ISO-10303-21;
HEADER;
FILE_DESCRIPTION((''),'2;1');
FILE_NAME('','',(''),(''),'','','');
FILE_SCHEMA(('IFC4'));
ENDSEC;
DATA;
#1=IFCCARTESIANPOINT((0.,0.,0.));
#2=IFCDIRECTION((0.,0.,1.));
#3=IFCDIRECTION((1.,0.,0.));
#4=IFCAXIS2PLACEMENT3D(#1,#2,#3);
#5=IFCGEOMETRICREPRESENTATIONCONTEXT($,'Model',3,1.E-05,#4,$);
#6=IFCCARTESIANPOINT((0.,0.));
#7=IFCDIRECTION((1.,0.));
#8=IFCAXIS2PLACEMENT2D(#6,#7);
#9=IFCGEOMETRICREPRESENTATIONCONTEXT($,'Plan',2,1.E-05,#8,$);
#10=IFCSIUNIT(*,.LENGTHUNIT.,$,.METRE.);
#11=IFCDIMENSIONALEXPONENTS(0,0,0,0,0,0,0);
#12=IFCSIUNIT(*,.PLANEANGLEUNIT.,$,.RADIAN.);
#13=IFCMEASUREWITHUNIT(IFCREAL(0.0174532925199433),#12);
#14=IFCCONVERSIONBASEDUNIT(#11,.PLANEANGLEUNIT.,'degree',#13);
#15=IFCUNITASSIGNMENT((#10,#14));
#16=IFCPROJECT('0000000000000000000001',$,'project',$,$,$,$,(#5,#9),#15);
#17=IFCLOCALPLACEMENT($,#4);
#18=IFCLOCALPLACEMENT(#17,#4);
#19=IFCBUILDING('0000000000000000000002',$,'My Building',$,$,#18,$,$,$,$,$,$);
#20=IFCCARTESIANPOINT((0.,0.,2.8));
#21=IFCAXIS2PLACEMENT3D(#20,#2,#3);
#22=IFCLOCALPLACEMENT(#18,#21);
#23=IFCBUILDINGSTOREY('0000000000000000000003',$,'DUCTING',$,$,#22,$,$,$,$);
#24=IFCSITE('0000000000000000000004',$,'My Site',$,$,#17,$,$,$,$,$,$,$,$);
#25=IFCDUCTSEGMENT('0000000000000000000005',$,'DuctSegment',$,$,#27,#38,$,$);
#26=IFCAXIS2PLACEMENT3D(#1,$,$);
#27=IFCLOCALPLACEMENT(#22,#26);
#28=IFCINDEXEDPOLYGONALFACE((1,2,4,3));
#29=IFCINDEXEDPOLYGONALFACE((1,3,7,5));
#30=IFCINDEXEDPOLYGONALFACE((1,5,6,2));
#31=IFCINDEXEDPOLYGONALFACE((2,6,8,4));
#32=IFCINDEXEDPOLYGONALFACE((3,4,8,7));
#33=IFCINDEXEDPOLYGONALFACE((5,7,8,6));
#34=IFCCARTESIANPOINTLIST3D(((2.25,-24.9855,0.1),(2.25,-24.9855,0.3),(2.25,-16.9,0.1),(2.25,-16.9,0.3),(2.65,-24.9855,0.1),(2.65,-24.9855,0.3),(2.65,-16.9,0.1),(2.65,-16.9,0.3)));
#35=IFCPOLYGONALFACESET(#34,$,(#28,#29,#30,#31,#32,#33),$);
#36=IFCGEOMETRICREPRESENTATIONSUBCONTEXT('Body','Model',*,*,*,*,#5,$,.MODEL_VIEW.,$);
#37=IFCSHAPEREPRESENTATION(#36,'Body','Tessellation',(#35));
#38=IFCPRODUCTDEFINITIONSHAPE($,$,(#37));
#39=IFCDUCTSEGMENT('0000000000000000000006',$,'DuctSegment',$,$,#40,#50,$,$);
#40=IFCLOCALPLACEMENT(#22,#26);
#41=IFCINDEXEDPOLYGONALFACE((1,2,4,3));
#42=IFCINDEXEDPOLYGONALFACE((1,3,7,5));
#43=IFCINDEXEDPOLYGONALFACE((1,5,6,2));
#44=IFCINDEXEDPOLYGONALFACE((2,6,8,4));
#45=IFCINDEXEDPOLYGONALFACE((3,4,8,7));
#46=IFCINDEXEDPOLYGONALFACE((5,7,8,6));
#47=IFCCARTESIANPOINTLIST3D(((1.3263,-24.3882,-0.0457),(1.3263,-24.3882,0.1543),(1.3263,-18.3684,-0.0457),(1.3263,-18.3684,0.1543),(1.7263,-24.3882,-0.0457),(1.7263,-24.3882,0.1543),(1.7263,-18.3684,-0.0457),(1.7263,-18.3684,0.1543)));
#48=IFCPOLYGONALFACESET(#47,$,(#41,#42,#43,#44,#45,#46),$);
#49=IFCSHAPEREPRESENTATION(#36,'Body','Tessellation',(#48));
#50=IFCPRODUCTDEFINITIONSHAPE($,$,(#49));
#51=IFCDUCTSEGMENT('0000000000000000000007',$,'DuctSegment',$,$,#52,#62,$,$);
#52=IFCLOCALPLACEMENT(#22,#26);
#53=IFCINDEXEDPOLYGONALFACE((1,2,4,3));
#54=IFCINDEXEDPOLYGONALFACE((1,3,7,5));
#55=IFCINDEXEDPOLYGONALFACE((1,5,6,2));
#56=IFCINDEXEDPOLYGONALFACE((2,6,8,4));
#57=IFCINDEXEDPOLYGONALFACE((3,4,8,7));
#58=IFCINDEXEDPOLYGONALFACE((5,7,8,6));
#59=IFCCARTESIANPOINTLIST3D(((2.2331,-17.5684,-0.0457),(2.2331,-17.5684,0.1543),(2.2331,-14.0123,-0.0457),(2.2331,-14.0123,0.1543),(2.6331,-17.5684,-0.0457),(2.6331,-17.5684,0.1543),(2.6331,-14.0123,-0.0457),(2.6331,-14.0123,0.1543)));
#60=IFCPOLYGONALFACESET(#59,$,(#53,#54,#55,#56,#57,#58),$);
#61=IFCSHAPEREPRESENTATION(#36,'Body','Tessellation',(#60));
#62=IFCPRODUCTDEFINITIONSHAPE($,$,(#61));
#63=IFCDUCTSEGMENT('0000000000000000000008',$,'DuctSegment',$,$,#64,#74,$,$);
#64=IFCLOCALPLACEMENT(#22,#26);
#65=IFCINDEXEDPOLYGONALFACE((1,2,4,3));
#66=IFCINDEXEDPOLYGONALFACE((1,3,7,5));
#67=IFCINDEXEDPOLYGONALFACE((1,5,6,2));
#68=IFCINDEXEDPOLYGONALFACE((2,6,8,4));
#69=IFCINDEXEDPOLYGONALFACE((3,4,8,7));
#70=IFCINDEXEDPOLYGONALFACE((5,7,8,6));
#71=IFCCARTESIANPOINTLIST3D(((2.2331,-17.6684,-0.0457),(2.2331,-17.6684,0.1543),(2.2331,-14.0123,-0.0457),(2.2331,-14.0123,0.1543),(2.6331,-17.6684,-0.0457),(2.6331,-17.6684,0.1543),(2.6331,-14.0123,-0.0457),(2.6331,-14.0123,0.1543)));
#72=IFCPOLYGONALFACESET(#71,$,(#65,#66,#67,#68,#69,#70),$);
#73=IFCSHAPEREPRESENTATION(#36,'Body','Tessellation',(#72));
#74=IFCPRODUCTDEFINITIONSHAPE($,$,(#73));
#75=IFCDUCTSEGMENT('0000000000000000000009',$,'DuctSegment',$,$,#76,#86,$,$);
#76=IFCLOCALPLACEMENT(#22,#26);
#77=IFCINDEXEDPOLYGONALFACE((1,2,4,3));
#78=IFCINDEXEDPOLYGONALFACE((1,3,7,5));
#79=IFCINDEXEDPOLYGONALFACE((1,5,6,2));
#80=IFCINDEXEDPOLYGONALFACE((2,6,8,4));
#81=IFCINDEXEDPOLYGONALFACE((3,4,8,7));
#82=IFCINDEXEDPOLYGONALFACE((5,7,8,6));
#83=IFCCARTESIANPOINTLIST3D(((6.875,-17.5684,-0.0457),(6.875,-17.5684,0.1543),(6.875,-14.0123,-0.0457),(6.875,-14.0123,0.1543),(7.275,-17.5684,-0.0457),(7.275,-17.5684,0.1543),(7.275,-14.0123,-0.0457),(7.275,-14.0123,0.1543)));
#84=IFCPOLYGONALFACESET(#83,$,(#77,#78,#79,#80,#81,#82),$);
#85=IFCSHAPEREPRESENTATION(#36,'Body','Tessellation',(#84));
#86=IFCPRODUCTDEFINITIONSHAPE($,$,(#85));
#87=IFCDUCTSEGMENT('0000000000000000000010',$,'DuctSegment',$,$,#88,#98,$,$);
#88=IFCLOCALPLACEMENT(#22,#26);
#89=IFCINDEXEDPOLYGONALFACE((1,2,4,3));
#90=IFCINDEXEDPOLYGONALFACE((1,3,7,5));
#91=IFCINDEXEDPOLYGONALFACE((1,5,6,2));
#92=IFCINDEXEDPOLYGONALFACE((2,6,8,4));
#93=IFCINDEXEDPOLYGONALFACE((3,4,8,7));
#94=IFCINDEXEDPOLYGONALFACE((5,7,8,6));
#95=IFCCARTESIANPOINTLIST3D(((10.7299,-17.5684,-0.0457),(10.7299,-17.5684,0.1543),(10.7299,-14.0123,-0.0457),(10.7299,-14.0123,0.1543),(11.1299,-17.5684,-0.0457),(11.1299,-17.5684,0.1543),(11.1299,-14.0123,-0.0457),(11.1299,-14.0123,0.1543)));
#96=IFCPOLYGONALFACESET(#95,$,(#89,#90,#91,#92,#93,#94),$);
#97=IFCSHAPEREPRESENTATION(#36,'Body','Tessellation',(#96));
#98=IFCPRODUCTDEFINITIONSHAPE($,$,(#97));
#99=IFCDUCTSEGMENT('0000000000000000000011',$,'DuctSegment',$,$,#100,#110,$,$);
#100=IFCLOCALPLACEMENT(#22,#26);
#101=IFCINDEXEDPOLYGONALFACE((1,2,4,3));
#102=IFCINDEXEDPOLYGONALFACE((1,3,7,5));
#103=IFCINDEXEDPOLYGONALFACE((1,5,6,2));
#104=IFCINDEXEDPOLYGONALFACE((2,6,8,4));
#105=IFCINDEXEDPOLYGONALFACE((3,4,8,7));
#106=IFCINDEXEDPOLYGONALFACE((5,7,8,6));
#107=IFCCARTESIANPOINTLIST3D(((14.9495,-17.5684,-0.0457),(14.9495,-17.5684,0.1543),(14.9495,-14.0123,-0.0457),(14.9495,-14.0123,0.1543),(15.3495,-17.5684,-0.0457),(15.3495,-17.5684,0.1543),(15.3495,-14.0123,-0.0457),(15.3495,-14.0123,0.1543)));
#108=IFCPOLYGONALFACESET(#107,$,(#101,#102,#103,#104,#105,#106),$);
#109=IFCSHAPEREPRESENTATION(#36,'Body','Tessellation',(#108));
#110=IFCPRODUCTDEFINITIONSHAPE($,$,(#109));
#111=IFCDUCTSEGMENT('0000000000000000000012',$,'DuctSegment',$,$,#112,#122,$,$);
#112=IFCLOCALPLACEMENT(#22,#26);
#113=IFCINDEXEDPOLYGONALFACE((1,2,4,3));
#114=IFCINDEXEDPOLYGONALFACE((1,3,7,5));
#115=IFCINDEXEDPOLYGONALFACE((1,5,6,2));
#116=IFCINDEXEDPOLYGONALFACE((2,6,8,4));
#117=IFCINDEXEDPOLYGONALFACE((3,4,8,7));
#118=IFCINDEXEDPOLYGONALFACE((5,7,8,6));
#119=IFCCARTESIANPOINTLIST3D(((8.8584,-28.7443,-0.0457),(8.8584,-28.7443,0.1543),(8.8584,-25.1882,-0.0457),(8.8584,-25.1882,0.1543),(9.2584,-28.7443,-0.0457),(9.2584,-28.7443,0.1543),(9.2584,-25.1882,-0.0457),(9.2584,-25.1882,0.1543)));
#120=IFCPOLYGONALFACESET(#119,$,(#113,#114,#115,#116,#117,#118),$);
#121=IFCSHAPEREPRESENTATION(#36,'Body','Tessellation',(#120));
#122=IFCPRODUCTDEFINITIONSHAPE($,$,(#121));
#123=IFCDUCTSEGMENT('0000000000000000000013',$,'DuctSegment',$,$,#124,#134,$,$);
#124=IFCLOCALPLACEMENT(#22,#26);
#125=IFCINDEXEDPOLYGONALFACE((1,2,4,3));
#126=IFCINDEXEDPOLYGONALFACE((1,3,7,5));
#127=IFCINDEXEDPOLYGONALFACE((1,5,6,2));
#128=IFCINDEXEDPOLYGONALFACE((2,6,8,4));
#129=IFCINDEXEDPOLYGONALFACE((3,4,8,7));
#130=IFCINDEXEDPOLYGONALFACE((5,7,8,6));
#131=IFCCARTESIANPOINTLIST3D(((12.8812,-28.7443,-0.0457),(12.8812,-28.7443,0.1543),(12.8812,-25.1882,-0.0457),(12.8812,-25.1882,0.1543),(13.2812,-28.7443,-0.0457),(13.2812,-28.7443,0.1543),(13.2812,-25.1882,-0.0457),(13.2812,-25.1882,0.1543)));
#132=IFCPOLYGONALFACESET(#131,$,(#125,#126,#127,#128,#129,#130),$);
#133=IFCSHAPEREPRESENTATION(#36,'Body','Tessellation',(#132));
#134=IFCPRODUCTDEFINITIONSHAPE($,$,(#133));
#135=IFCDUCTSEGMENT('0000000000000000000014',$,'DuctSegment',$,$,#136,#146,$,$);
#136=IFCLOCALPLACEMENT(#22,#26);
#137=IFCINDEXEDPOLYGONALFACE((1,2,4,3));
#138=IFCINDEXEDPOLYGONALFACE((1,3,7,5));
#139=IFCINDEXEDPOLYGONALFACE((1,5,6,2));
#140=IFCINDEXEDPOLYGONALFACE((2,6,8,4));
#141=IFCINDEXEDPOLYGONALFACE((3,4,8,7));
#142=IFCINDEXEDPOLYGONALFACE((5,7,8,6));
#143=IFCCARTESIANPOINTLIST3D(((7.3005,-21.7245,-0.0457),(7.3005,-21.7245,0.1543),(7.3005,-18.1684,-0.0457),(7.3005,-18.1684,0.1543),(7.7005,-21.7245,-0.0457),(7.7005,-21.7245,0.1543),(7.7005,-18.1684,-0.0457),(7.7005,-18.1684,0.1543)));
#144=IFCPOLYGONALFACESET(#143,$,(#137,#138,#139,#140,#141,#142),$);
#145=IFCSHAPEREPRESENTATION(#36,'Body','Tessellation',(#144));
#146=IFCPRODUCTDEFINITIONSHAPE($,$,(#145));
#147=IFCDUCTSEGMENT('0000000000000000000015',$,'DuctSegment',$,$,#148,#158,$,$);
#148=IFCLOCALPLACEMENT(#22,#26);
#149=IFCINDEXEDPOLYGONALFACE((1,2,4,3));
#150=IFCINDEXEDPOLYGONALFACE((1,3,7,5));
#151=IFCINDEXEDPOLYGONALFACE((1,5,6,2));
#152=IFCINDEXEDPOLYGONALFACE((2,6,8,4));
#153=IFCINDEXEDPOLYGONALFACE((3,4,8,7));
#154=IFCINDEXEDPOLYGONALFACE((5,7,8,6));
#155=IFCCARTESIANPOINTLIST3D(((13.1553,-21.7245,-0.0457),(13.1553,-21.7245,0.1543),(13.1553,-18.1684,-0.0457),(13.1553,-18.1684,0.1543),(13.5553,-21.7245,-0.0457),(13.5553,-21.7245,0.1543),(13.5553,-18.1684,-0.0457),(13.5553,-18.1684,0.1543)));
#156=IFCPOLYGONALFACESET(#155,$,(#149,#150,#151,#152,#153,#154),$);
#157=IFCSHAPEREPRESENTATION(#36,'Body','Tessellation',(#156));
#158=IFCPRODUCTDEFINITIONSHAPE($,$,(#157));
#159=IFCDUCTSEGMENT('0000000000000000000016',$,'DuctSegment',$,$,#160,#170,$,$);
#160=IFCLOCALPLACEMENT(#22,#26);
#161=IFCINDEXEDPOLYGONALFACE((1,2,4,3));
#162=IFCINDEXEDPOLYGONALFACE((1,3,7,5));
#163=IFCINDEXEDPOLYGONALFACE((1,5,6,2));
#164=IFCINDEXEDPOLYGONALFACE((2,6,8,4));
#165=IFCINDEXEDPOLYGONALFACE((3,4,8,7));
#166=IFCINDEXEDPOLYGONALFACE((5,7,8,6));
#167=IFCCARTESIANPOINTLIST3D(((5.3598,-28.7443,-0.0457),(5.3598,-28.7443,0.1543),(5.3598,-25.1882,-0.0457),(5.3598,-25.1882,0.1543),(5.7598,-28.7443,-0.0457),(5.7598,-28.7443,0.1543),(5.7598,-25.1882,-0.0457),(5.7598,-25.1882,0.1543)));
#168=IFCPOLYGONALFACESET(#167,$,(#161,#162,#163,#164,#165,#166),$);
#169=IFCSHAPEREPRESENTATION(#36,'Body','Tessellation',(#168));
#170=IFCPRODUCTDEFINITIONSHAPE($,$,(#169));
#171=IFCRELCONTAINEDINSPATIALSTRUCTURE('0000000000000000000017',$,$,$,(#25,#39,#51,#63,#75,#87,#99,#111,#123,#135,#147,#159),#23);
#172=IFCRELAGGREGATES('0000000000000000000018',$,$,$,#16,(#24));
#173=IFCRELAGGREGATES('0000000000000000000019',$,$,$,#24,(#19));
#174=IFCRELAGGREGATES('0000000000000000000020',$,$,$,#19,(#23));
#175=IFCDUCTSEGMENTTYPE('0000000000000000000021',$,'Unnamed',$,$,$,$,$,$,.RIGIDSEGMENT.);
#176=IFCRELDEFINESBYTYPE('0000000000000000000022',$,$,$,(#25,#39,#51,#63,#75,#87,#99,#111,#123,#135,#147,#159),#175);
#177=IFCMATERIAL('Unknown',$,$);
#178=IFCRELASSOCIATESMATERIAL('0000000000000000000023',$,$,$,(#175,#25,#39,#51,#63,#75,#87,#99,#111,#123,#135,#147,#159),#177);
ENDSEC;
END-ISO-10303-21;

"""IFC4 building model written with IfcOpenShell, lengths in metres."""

from ifc_helpers import new_model, entity, si_unit, converted_unit, frame, origin_with_axes, origin_2d_with_axis, place, context, subcontext, project, spatial, rectangle, extrude, material, material_profile, profile_set, profile_usage, type_object, element, save


model = new_model("IFC4")

# Units and contexts
model_context = context("Model", 3, precision=1e-05, world=origin_with_axes())
plan_context = context("Plan", 2, precision=1e-05, world=origin_2d_with_axis())
body_context = subcontext(model_context, "Body", "Model", "MODEL_VIEW")
ifc_project = project(units=[si_unit("LENGTHUNIT", "METRE"), converted_unit("PLANEANGLEUNIT", "degree", entity("IfcReal", 0.0174532925199433), si_unit("PLANEANGLEUNIT", "RADIAN"), dimensions=[0, 0, 0, 0, 0, 0, 0])], contexts=[model_context, plan_context])

# Site, building, storey
site_placement = place(None, origin_with_axes())
site = spatial("IfcSite", under=ifc_project, at=site_placement, Name="My Site")
building_placement = place(site_placement, origin_with_axes())
building = spatial("IfcBuilding", under=site, at=building_placement, Name="My Building")
storey_placement = place(building_placement, frame((0.0, 0.0, 2.8), z_axis=(0.0, 0.0, 1.0), x_axis=(1.0, 0.0, 0.0)))
storey = spatial("IfcBuildingStorey", under=building, at=storey_placement, Name="DUCTING")

# Duct segments
ifc_material = material(Name="Unknown")
ifc_material_profile_1 = material_profile(ifc_material, rectangle(XDim=0.4, YDim=0.2))
ifc_profile_set_1 = profile_set([ifc_material_profile_1])
ifc_profile_usage_1 = profile_usage(ifc_profile_set_1, cardinal=5)
duct_segment_type = type_object("IfcDuctSegmentType", Name="Unnamed", PredefinedType="RIGIDSEGMENT", material=ifc_profile_set_1)
duct_segment_1_placement = place(storey_placement, frame((2.45, -16.9, 0.2), z_axis=(0.0, -1.0, 0.0), x_axis=(1.0, 0.0, 0.0)))
element("IfcDuctSegment", 1, at=duct_segment_1_placement, inside=storey, type_object=duct_segment_type, material=ifc_profile_usage_1, Name="DuctSegment", context=body_context, shape_type="SweptSolid", body=[
    extrude(rectangle(XDim=0.4, YDim=0.2), origin_with_axes(), (0.0, 0.0, 1.0), 8.0855),
])
ifc_profile_usage_2 = profile_usage(ifc_profile_set_1, cardinal=5)
duct_segment_2_placement = place(storey_placement, frame((1.5263, -18.3684, 0.0543), z_axis=(0.0, -1.0, 0.0), x_axis=(1.0, 0.0, 0.0)))
element("IfcDuctSegment", 2, at=duct_segment_2_placement, inside=storey, type_object=duct_segment_type, material=ifc_profile_usage_2, Name="DuctSegment", context=body_context, shape_type="SweptSolid", body=[
    extrude(rectangle(XDim=0.4, YDim=0.2), origin_with_axes(), (0.0, 0.0, 1.0), 6.0198),
])
ifc_profile_usage_3 = profile_usage(ifc_profile_set_1, cardinal=5)
duct_segment_3_placement = place(storey_placement, frame((2.4331, -14.0123, 0.0543), z_axis=(0.0, -1.0, 0.0), x_axis=(1.0, 0.0, 0.0)))
element("IfcDuctSegment", 3, at=duct_segment_3_placement, inside=storey, type_object=duct_segment_type, material=ifc_profile_usage_3, Name="DuctSegment", context=body_context, shape_type="SweptSolid", body=[
    extrude(rectangle(XDim=0.4, YDim=0.2), origin_with_axes(), (0.0, 0.0, 1.0), 3.5561),
])
ifc_profile_usage_4 = profile_usage(ifc_profile_set_1, cardinal=5)
duct_segment_4_placement = place(storey_placement, frame((2.4331, -14.0123, 0.0543), z_axis=(0.0, -1.0, 0.0), x_axis=(1.0, 0.0, 0.0)))
element("IfcDuctSegment", 4, at=duct_segment_4_placement, inside=storey, type_object=duct_segment_type, material=ifc_profile_usage_4, Name="DuctSegment", context=body_context, shape_type="SweptSolid", body=[
    extrude(rectangle(XDim=0.4, YDim=0.2), origin_with_axes(), (0.0, 0.0, 1.0), 3.6561),
])
ifc_profile_usage_5 = profile_usage(ifc_profile_set_1, cardinal=5)
duct_segment_5_placement = place(storey_placement, frame((7.075, -14.0123, 0.0543), z_axis=(0.0, -1.0, 0.0), x_axis=(1.0, 0.0, 0.0)))
element("IfcDuctSegment", 5, at=duct_segment_5_placement, inside=storey, type_object=duct_segment_type, material=ifc_profile_usage_5, Name="DuctSegment", context=body_context, shape_type="SweptSolid", body=[
    extrude(rectangle(XDim=0.4, YDim=0.2), origin_with_axes(), (0.0, 0.0, 1.0), 3.5561),
])
ifc_profile_usage_6 = profile_usage(ifc_profile_set_1, cardinal=5)
duct_segment_6_placement = place(storey_placement, frame((10.9299, -14.0123, 0.0543), z_axis=(0.0, -1.0, 0.0), x_axis=(1.0, 0.0, 0.0)))
element("IfcDuctSegment", 6, at=duct_segment_6_placement, inside=storey, type_object=duct_segment_type, material=ifc_profile_usage_6, Name="DuctSegment", context=body_context, shape_type="SweptSolid", body=[
    extrude(rectangle(XDim=0.4, YDim=0.2), origin_with_axes(), (0.0, 0.0, 1.0), 3.5561),
])
ifc_profile_usage_7 = profile_usage(ifc_profile_set_1, cardinal=5)
duct_segment_7_placement = place(storey_placement, frame((15.1495, -14.0123, 0.0543), z_axis=(0.0, -1.0, 0.0), x_axis=(1.0, 0.0, 0.0)))
element("IfcDuctSegment", 7, at=duct_segment_7_placement, inside=storey, type_object=duct_segment_type, material=ifc_profile_usage_7, Name="DuctSegment", context=body_context, shape_type="SweptSolid", body=[
    extrude(rectangle(XDim=0.4, YDim=0.2), origin_with_axes(), (0.0, 0.0, 1.0), 3.5561),
])
ifc_profile_usage_8 = profile_usage(ifc_profile_set_1, cardinal=5)
duct_segment_8_placement = place(storey_placement, frame((9.0584, -28.7443, 0.0543), z_axis=(0.0, 1.0, 0.0), x_axis=(-1.0, 0.0, 0.0)))
element("IfcDuctSegment", 8, at=duct_segment_8_placement, inside=storey, type_object=duct_segment_type, material=ifc_profile_usage_8, Name="DuctSegment", context=body_context, shape_type="SweptSolid", body=[
    extrude(rectangle(XDim=0.4, YDim=0.2), origin_with_axes(), (0.0, 0.0, 1.0), 3.5561),
])
ifc_profile_usage_9 = profile_usage(ifc_profile_set_1, cardinal=5)
duct_segment_9_placement = place(storey_placement, frame((13.0812, -28.7443, 0.0543), z_axis=(0.0, 1.0, 0.0), x_axis=(-1.0, 0.0, 0.0)))
element("IfcDuctSegment", 9, at=duct_segment_9_placement, inside=storey, type_object=duct_segment_type, material=ifc_profile_usage_9, Name="DuctSegment", context=body_context, shape_type="SweptSolid", body=[
    extrude(rectangle(XDim=0.4, YDim=0.2), origin_with_axes(), (0.0, 0.0, 1.0), 3.5561),
])
ifc_profile_usage_10 = profile_usage(ifc_profile_set_1, cardinal=5)
duct_segment_10_placement = place(storey_placement, frame((7.5005, -21.7245, 0.0543), z_axis=(0.0, 1.0, 0.0), x_axis=(-1.0, 0.0, 0.0)))
element("IfcDuctSegment", 10, at=duct_segment_10_placement, inside=storey, type_object=duct_segment_type, material=ifc_profile_usage_10, Name="DuctSegment", context=body_context, shape_type="SweptSolid", body=[
    extrude(rectangle(XDim=0.4, YDim=0.2), origin_with_axes(), (0.0, 0.0, 1.0), 3.5561),
])
ifc_profile_usage_11 = profile_usage(ifc_profile_set_1, cardinal=5)
duct_segment_11_placement = place(storey_placement, frame((13.3553, -21.7245, 0.0543), z_axis=(0.0, 1.0, 0.0), x_axis=(-1.0, 0.0, 0.0)))
element("IfcDuctSegment", 11, at=duct_segment_11_placement, inside=storey, type_object=duct_segment_type, material=ifc_profile_usage_11, Name="DuctSegment", context=body_context, shape_type="SweptSolid", body=[
    extrude(rectangle(XDim=0.4, YDim=0.2), origin_with_axes(), (0.0, 0.0, 1.0), 3.5561),
])
ifc_profile_usage_12 = profile_usage(ifc_profile_set_1, cardinal=5)
duct_segment_12_placement = place(storey_placement, frame((5.5598, -28.7443, 0.0543), z_axis=(0.0, 1.0, 0.0), x_axis=(-1.0, 0.0, 0.0)))
element("IfcDuctSegment", 12, at=duct_segment_12_placement, inside=storey, type_object=duct_segment_type, material=ifc_profile_usage_12, Name="DuctSegment", context=body_context, shape_type="SweptSolid", body=[
    extrude(rectangle(XDim=0.4, YDim=0.2), origin_with_axes(), (0.0, 0.0, 1.0), 3.5561),
])

save(model, "model.ifc")
